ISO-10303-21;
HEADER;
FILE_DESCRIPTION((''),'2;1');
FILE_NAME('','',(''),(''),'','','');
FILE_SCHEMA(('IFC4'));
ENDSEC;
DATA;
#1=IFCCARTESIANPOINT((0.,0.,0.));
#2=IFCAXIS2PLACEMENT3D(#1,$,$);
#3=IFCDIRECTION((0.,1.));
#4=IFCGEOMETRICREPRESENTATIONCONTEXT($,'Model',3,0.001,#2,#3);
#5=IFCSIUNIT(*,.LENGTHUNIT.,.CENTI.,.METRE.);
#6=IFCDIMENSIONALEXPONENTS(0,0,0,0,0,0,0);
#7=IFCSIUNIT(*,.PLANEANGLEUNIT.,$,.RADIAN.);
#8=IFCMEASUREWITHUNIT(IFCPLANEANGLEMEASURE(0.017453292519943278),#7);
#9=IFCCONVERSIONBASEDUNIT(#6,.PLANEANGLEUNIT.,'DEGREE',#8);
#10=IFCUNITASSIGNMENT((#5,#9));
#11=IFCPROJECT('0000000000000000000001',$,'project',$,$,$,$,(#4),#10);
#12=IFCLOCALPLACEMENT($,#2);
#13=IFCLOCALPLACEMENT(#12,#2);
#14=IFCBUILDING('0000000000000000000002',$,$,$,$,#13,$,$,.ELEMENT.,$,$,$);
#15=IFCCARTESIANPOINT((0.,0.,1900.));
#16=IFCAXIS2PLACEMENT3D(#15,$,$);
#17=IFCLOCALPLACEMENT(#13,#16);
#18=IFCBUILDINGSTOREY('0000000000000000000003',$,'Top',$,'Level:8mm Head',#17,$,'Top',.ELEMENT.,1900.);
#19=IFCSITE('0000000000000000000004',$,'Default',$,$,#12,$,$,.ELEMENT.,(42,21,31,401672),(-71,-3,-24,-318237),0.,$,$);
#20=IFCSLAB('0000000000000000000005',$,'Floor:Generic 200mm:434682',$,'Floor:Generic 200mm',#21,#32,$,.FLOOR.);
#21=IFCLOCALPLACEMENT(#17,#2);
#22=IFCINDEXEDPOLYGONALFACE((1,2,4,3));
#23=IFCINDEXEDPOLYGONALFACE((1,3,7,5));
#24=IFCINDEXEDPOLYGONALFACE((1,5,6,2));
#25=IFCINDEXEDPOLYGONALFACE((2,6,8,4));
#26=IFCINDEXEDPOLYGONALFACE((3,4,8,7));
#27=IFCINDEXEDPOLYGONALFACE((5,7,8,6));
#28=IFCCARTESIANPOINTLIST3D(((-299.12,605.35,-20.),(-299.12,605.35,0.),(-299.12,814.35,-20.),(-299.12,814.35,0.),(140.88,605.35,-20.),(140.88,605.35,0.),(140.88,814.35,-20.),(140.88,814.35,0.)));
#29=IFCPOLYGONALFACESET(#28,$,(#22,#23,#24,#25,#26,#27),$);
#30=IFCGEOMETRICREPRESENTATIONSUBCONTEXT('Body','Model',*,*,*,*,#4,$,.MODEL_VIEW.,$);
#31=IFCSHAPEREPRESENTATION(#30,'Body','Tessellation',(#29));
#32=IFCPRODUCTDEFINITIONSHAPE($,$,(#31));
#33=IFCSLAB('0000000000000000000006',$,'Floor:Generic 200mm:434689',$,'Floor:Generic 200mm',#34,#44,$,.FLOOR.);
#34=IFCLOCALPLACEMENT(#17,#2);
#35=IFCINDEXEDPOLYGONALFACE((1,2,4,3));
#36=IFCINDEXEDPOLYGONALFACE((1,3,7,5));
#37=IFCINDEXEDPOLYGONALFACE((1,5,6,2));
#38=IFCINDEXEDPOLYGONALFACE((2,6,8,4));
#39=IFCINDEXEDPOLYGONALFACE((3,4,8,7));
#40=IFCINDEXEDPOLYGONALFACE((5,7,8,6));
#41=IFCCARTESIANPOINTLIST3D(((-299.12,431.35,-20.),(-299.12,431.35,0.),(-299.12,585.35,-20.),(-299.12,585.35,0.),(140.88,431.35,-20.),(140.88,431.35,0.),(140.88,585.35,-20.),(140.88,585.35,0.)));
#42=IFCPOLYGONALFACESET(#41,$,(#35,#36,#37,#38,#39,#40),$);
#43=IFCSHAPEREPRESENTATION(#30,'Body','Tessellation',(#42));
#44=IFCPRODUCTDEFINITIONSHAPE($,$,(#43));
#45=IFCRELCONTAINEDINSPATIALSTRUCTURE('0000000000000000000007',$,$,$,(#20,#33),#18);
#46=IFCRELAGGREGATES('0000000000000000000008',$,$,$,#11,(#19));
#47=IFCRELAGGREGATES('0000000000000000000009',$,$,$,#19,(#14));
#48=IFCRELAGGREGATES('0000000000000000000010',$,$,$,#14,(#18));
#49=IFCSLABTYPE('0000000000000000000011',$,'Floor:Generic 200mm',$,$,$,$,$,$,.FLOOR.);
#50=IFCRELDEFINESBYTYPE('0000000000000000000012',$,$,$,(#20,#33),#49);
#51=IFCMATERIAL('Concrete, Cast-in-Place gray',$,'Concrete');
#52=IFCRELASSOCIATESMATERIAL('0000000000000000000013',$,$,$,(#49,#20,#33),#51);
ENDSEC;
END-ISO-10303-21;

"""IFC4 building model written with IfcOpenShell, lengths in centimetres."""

from ifc_helpers import new_model, entity, si_unit, converted_unit, direction, frame, origin, place, context, subcontext, project, spatial, indexed_curve, outline, extrude, material, type_object, element, save


model = new_model("IFC4")

# Units and contexts
model_context = context("Model", 3, precision=0.001, world=origin(), true_north=direction((0.0, 1.0)))
body_context = subcontext(model_context, "Body", "Model", "MODEL_VIEW")
ifc_project = project(units=[si_unit("LENGTHUNIT", "METRE", prefix="CENTI"), converted_unit("PLANEANGLEUNIT", "DEGREE", entity("IfcPlaneAngleMeasure", 0.017453292519943278), si_unit("PLANEANGLEUNIT", "RADIAN"), dimensions=[0, 0, 0, 0, 0, 0, 0])], contexts=[model_context])

# Site, building, storey
site_placement = place(None, origin())
site = spatial("IfcSite", under=ifc_project, at=site_placement, Name="Default", CompositionType="ELEMENT", RefLatitude=(42, 21, 31, 401672), RefLongitude=(-71, -3, -24, -318237), RefElevation=0.0)
building_placement = place(site_placement, origin())
building = spatial("IfcBuilding", under=site, at=building_placement, CompositionType="ELEMENT")
storey_placement = place(building_placement, frame((0.0, 0.0, 1900.0)))
storey = spatial("IfcBuildingStorey", under=building, at=storey_placement, Name="Top", ObjectType="Level:8mm Head", LongName="Top", CompositionType="ELEMENT", Elevation=1900.0)

# Slabs
ifc_material = material(Name="Concrete, Cast-in-Place gray", Category="Concrete")
slab_type = type_object("IfcSlabType", Name="Floor:Generic 200mm", PredefinedType="FLOOR", material=ifc_material)
slab_1_placement = place(storey_placement, origin())
element("IfcSlab", 1, at=slab_1_placement, inside=storey, type_object=slab_type, material=ifc_material, Name="Floor:Generic 200mm:434682", ObjectType="Floor:Generic 200mm", PredefinedType="FLOOR", context=body_context, shape_type="SweptSolid", body=[
    extrude(outline(indexed_curve([(-104.5, -220.0), (104.5, -220.0), (104.5, 220.0), (-104.5, 220.0), (-104.5, -220.0)], self_intersect=False)), frame((-79.12, 709.85, 0.0), z_axis=(0.0, 0.0, -1.0), x_axis=(0.0, 1.0, 0.0)), (0.0, 0.0, 1.0), 20.0),
])
slab_2_placement = place(storey_placement, origin())
element("IfcSlab", 2, at=slab_2_placement, inside=storey, type_object=slab_type, material=ifc_material, Name="Floor:Generic 200mm:434689", ObjectType="Floor:Generic 200mm", PredefinedType="FLOOR", context=body_context, shape_type="SweptSolid", body=[
    extrude(outline(indexed_curve([(-77.0, -220.0), (77.0, -220.0), (77.0, 220.0), (-77.0, 220.0), (-77.0, -220.0)], self_intersect=False)), frame((-79.12, 508.35, 0.0), z_axis=(0.0, 0.0, -1.0), x_axis=(0.0, 1.0, 0.0)), (0.0, 0.0, 1.0), 20.0),
])

save(model, "model.ifc")
